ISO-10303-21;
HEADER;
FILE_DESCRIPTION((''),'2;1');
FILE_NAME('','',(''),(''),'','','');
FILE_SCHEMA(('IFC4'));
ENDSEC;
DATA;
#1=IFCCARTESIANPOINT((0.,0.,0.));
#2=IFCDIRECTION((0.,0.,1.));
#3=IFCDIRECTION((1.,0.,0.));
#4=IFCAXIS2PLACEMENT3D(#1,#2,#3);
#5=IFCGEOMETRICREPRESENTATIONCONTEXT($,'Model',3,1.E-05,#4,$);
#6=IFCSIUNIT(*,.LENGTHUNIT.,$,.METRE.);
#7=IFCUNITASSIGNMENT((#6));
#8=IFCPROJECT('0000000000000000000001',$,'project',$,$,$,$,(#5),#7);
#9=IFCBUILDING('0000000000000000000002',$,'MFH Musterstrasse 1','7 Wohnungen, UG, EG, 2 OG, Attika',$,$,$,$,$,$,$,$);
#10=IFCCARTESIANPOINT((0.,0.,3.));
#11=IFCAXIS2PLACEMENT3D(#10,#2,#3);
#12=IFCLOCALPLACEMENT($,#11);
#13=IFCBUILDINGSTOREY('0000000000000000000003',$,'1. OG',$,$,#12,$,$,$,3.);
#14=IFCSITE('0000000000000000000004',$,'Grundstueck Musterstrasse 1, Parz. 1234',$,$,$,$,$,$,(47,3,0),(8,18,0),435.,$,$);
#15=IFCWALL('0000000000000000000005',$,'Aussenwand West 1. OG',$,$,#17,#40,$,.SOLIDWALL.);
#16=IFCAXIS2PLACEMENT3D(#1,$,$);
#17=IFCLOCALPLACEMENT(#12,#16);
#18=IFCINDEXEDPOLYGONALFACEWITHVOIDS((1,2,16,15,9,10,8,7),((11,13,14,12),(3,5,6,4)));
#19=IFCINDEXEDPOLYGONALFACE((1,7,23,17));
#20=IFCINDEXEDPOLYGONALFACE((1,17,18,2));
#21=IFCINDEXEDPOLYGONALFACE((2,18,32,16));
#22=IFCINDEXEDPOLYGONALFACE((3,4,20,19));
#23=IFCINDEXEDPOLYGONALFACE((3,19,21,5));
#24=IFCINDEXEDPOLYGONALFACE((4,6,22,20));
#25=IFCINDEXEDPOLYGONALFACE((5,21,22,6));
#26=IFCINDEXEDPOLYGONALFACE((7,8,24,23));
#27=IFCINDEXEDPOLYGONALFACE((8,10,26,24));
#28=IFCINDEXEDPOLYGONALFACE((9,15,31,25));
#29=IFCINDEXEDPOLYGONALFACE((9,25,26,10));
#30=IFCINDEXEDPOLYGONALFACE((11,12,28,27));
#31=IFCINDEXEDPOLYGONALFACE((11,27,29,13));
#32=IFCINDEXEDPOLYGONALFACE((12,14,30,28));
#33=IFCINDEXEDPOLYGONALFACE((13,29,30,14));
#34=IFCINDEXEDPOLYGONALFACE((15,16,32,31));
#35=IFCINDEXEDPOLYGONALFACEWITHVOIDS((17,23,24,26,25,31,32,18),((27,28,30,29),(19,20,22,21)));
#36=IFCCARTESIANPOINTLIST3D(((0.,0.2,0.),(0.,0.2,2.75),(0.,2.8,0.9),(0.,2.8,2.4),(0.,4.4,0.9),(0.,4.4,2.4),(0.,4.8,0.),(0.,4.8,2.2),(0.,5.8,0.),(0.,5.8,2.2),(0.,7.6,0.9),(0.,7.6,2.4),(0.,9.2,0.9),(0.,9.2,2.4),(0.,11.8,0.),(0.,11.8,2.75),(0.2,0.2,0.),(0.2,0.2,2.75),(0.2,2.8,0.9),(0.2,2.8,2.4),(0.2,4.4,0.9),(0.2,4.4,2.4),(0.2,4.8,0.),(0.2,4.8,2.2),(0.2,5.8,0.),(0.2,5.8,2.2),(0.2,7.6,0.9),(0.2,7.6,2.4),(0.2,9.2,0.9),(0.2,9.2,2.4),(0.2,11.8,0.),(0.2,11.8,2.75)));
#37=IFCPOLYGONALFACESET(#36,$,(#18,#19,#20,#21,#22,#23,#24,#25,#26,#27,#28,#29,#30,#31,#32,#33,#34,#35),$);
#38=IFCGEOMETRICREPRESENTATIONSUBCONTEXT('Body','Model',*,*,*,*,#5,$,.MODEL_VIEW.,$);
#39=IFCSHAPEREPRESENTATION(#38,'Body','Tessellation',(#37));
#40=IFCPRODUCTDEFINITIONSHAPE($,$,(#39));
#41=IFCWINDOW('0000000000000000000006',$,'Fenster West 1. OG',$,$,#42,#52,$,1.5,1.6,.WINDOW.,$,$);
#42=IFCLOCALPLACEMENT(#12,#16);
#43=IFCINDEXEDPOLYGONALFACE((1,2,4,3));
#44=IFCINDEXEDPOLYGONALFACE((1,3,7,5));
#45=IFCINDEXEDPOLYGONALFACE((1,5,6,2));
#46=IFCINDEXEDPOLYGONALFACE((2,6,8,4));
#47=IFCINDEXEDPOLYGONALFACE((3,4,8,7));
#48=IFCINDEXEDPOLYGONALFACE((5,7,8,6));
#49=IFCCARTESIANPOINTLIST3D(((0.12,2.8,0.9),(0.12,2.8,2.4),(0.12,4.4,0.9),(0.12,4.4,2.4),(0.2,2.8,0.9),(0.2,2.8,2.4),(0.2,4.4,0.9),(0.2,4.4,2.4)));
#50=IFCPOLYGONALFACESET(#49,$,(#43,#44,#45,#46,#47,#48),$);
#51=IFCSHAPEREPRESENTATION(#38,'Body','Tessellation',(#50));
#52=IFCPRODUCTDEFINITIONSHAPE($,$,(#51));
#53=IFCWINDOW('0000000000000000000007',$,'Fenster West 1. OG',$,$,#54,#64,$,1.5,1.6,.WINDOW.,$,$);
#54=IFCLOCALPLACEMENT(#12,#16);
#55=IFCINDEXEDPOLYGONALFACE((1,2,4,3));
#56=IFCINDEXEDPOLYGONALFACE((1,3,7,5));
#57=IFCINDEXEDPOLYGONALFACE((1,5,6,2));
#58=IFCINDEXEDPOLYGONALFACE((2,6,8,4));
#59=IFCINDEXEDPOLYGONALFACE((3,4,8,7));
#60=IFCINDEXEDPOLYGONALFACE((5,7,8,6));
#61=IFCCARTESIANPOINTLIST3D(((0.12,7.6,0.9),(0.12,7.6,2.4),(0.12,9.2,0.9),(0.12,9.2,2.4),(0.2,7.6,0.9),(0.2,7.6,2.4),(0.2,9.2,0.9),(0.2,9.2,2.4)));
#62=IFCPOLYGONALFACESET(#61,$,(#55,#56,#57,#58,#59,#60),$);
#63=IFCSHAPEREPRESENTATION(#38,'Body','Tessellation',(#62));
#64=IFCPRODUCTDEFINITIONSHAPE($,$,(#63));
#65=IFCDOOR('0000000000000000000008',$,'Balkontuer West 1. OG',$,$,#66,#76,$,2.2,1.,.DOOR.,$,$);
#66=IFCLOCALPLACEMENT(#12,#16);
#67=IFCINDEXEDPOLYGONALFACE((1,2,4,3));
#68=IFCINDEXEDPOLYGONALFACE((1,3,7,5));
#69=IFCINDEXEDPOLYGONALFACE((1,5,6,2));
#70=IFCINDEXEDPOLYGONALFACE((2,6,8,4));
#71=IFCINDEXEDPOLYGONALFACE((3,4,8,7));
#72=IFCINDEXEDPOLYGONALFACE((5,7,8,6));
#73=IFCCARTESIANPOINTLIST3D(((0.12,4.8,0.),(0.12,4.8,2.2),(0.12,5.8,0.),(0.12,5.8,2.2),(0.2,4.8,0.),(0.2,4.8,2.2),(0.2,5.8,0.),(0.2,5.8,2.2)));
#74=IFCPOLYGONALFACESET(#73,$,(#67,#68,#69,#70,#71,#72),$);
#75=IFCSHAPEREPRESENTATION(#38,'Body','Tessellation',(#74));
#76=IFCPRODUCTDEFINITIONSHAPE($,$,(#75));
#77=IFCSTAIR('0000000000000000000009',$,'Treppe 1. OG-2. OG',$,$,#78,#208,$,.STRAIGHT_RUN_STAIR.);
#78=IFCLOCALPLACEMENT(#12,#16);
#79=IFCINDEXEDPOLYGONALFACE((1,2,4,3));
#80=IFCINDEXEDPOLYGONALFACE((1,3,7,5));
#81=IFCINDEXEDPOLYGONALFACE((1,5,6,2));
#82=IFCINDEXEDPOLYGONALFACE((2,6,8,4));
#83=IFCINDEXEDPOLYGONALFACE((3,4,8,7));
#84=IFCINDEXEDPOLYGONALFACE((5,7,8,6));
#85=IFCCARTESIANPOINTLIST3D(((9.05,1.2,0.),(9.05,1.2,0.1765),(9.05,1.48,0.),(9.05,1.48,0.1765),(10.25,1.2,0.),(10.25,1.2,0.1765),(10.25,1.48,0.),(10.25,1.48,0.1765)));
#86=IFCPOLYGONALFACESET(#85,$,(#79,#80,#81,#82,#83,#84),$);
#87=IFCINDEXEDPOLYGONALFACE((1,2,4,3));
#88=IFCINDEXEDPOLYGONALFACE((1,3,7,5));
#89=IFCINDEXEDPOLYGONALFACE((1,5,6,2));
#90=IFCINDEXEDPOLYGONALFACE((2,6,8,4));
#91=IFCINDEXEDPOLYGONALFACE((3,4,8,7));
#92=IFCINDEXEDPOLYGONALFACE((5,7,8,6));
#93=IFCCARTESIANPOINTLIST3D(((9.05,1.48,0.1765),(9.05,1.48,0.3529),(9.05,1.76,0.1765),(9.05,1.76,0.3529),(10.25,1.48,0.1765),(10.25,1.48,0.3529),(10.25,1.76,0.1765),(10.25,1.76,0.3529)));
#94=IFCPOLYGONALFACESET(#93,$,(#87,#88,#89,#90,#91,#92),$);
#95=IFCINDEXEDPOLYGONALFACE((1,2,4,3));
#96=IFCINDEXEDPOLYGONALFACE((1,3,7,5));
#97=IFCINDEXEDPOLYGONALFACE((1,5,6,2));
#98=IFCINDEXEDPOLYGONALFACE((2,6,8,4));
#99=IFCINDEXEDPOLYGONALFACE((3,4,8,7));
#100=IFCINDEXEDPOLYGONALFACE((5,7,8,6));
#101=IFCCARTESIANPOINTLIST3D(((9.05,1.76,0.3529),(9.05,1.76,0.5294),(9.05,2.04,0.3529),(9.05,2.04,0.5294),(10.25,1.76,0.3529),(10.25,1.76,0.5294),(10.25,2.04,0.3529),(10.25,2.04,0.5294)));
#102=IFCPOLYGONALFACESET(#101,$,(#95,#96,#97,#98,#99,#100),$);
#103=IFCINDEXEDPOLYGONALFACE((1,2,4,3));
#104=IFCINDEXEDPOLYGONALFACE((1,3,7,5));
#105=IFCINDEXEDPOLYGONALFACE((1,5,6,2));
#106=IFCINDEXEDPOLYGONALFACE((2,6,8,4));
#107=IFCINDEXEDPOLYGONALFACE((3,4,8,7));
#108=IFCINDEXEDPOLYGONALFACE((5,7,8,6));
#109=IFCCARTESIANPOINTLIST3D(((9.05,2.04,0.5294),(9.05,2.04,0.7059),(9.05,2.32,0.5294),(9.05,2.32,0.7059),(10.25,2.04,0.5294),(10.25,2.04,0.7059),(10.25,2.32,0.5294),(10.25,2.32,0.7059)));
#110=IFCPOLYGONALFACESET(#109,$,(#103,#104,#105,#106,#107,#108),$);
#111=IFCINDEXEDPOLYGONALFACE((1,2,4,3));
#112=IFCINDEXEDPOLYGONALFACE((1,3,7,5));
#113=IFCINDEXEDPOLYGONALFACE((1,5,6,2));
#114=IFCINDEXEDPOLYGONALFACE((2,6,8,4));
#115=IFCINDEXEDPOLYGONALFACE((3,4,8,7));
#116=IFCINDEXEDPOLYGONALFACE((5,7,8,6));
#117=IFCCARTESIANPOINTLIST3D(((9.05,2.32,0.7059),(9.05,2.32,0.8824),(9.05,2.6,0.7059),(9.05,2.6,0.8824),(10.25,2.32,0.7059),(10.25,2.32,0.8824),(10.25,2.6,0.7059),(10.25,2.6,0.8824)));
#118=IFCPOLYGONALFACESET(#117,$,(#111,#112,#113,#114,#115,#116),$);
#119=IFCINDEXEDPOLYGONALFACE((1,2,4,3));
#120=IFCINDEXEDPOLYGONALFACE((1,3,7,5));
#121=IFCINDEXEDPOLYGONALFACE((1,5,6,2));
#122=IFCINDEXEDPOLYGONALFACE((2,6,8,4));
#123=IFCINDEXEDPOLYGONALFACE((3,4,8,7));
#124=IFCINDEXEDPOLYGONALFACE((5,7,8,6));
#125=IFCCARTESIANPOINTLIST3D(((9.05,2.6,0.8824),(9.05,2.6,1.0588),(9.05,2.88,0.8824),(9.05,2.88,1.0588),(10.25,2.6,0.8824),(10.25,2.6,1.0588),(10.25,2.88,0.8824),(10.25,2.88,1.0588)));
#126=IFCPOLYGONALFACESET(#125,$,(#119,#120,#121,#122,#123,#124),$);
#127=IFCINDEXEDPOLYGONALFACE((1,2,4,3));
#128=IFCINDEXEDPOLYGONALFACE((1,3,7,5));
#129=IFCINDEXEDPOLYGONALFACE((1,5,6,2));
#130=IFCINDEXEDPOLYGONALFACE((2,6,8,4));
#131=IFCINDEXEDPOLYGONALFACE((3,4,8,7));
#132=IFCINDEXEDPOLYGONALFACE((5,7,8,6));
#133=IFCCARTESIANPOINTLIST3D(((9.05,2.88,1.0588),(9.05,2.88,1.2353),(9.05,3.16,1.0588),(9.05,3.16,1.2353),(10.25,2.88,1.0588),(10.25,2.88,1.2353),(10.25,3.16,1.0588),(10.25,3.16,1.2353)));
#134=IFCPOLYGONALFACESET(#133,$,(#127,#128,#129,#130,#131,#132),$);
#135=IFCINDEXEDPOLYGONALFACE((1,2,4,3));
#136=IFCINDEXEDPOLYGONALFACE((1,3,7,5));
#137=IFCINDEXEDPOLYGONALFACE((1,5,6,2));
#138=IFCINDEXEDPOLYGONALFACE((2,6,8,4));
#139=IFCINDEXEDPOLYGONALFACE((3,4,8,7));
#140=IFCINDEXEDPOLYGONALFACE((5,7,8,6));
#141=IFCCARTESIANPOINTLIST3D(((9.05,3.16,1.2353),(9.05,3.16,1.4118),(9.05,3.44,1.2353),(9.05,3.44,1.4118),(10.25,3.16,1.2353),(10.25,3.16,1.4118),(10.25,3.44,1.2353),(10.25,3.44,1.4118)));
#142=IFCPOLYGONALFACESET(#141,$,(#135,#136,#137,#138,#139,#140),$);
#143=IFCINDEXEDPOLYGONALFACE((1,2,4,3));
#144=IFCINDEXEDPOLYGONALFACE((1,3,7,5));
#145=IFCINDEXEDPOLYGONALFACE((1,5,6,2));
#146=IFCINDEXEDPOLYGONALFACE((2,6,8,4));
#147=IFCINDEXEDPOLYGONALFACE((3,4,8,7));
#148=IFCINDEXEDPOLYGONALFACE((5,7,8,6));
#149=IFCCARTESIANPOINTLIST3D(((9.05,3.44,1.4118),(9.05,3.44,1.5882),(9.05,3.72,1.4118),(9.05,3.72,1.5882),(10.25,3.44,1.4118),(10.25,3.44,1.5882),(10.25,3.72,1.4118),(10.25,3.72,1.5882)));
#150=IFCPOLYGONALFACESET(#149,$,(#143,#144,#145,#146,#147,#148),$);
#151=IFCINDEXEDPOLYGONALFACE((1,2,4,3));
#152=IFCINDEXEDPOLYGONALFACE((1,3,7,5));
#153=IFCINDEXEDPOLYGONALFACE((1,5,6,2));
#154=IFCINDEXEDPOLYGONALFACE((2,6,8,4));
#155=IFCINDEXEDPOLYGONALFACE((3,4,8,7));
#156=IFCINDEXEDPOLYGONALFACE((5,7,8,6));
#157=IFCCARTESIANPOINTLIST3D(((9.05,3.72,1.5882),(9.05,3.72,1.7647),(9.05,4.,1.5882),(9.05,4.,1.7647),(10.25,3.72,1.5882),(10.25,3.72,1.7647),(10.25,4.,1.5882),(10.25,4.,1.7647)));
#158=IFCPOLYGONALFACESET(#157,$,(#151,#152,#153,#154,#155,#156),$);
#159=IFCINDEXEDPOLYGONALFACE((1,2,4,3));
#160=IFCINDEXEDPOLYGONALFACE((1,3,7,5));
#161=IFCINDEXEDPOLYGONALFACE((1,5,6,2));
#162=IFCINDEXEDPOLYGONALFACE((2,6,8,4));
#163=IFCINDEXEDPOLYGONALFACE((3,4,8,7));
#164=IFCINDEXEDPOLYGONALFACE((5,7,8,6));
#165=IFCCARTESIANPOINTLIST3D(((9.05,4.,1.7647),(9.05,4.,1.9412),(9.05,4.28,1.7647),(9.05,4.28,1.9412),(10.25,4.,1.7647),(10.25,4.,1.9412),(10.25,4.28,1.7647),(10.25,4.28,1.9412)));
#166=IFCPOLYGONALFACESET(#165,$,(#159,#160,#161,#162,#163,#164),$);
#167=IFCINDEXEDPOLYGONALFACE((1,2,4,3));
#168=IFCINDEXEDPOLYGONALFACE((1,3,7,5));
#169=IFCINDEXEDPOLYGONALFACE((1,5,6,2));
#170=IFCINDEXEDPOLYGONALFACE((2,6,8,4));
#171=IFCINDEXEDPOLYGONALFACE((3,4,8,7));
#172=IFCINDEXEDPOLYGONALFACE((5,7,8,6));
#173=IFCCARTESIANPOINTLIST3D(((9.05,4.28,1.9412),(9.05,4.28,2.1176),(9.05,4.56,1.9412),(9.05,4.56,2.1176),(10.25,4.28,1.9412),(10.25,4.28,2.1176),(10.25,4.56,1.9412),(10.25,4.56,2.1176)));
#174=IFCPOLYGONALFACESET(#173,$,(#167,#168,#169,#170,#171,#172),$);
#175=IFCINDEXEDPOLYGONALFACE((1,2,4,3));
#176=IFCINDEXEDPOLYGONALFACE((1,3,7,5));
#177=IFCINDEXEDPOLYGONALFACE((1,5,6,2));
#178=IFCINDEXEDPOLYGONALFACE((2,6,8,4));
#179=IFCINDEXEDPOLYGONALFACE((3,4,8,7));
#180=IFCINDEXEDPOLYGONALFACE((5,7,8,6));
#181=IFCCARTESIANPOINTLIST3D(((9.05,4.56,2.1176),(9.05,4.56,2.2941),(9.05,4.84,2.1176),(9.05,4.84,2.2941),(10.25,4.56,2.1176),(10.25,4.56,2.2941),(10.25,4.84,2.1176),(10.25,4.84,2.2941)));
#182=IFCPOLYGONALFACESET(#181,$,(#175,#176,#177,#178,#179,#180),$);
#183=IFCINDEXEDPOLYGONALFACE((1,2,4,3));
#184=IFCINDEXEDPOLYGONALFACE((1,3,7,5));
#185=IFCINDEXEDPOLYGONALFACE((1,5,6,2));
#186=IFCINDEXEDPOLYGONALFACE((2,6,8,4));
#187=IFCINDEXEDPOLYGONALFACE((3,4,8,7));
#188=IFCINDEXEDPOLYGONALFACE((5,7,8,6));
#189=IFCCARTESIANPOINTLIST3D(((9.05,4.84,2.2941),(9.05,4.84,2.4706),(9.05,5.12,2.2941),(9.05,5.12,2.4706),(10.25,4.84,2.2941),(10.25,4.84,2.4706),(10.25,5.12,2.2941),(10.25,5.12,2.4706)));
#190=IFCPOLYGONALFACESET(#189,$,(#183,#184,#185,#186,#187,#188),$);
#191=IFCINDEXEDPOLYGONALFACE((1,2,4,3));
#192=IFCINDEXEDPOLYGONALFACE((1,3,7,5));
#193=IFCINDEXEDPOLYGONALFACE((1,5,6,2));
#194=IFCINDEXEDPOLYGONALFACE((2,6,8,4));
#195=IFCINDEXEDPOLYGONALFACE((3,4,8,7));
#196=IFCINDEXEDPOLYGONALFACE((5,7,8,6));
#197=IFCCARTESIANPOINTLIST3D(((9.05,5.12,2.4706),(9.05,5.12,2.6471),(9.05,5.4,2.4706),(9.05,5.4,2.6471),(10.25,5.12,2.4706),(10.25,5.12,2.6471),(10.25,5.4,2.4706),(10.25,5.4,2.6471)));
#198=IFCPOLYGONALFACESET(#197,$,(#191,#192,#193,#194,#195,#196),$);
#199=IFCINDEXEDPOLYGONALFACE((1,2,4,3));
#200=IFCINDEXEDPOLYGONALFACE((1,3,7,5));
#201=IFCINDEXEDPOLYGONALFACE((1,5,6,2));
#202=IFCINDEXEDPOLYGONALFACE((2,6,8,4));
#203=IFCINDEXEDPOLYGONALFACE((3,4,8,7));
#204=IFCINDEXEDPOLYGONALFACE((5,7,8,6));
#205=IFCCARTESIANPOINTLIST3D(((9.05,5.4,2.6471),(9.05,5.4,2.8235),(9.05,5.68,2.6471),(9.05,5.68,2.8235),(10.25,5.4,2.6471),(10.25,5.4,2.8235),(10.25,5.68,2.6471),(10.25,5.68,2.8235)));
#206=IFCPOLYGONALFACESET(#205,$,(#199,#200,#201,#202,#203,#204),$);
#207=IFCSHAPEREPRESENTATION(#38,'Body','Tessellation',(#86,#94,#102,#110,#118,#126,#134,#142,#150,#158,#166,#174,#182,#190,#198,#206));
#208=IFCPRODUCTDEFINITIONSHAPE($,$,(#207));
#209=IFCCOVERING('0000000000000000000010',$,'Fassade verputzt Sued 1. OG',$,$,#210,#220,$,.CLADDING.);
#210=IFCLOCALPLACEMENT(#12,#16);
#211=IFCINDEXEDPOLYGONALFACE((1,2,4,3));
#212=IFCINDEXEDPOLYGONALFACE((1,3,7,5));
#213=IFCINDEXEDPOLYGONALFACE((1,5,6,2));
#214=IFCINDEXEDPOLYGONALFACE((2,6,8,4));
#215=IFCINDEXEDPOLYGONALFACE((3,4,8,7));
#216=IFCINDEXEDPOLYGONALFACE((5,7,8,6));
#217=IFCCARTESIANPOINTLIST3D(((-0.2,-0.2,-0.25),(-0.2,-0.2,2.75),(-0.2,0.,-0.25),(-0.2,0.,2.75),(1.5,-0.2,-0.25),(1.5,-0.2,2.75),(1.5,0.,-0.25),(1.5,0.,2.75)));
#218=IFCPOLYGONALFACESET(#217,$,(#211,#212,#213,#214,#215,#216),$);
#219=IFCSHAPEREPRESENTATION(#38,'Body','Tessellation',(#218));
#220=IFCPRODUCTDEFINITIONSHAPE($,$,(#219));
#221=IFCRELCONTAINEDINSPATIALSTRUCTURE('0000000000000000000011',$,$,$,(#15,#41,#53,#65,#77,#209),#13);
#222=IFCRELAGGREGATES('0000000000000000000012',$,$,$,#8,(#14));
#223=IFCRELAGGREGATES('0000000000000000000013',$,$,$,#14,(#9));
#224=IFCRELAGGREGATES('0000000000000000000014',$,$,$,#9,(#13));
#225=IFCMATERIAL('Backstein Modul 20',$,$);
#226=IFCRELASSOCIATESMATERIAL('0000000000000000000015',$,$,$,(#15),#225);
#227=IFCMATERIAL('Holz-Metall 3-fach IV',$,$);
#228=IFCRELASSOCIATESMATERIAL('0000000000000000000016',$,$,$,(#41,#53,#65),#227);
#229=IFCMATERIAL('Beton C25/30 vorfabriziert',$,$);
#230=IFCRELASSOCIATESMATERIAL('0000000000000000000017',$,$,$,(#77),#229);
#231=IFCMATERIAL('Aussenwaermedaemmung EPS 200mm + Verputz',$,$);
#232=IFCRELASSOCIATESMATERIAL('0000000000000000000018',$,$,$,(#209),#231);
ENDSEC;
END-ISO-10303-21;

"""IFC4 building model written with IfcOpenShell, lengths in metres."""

from ifc_helpers import new_model, si_unit, frame, frame_2d, origin_with_axes, place, context, subcontext, project, spatial, rectangle, extrude, material, element, fill, save


model = new_model("IFC4")

# Units and contexts
model_context = context("Model", 3, precision=1e-05, world=origin_with_axes())
body_context = subcontext(model_context, "Body", "Model", "MODEL_VIEW")
ifc_project = project(units=[si_unit("LENGTHUNIT", "METRE")], contexts=[model_context])

# Site, building, storey
site = spatial("IfcSite", under=ifc_project, Name="Grundstueck Musterstrasse 1, Parz. 1234", RefLatitude=(47, 3, 0), RefLongitude=(8, 18, 0), RefElevation=435.0)
building = spatial("IfcBuilding", under=site, Name="MFH Musterstrasse 1", Description="7 Wohnungen, UG, EG, 2 OG, Attika")
storey_placement = place(None, frame((0.0, 0.0, 3.0), z_axis=(0.0, 0.0, 1.0), x_axis=(1.0, 0.0, 0.0)))
storey = spatial("IfcBuildingStorey", under=building, at=storey_placement, Name="1. OG", Elevation=3.0)

# Shared definitions
ifc_material_1 = material(Name="Backstein Modul 20")

# Shared definitions
ifc_material_2 = material(Name="Holz-Metall 3-fach IV")

# Wall, openings, windows, door
wall_1_placement = place(storey_placement, frame((0.0, 0.2, 0.0), z_axis=(0.0, 0.0, 1.0), x_axis=(1.0, 0.0, 0.0)))
wall_1 = element("IfcWall", 1, at=wall_1_placement, inside=storey, material=ifc_material_1, Name="Aussenwand West 1. OG", PredefinedType="SOLIDWALL", context=body_context, shape_type="SweptSolid", body=[
    extrude(rectangle(XDim=0.2, YDim=11.6, at=frame_2d((0.1, 5.8))), origin_with_axes(), (0.0, 0.0, 1.0), 2.75),
])
opening_1_placement = place(wall_1_placement, frame((-0.21, 2.6, 0.9), z_axis=(0.0, 0.0, 1.0), x_axis=(1.0, 0.0, 0.0)))
opening_1 = element("IfcOpeningElement", 2, at=opening_1_placement, cuts=wall_1, context=body_context, shape_type="SweptSolid", body=[
    extrude(rectangle(XDim=0.42, YDim=1.6, at=frame_2d((0.21, 0.8))), origin_with_axes(), (0.0, 0.0, 1.0), 1.5),
])
opening_2_placement = place(wall_1_placement, frame((-0.21, 7.4, 0.9), z_axis=(0.0, 0.0, 1.0), x_axis=(1.0, 0.0, 0.0)))
opening_2 = element("IfcOpeningElement", 3, at=opening_2_placement, cuts=wall_1, context=body_context, shape_type="SweptSolid", body=[
    extrude(rectangle(XDim=0.42, YDim=1.6, at=frame_2d((0.21, 0.8))), origin_with_axes(), (0.0, 0.0, 1.0), 1.5),
])
opening_3_placement = place(wall_1_placement, frame((-0.21, 4.6, 0.0), z_axis=(0.0, 0.0, 1.0), x_axis=(1.0, 0.0, 0.0)))
opening_3 = element("IfcOpeningElement", 4, at=opening_3_placement, cuts=wall_1, context=body_context, shape_type="SweptSolid", body=[
    extrude(rectangle(XDim=0.42, YDim=1.0, at=frame_2d((0.21, 0.5))), origin_with_axes(), (0.0, 0.0, 1.0), 2.2),
])
window_1_placement = place(storey_placement, frame((0.12, 2.8, 0.9), z_axis=(0.0, 0.0, 1.0), x_axis=(1.0, 0.0, 0.0)))
window_1 = element("IfcWindow", 5, at=window_1_placement, inside=storey, material=ifc_material_2, Name="Fenster West 1. OG", OverallHeight=1.5, OverallWidth=1.6, PredefinedType="WINDOW", context=body_context, shape_type="SweptSolid", body=[
    extrude(rectangle(XDim=0.08, YDim=1.6, at=frame_2d((0.04, 0.8))), origin_with_axes(), (0.0, 0.0, 1.0), 1.5),
])
fill(opening_1, window_1)
window_2_placement = place(storey_placement, frame((0.12, 7.6, 0.9), z_axis=(0.0, 0.0, 1.0), x_axis=(1.0, 0.0, 0.0)))
window_2 = element("IfcWindow", 6, at=window_2_placement, inside=storey, material=ifc_material_2, Name="Fenster West 1. OG", OverallHeight=1.5, OverallWidth=1.6, PredefinedType="WINDOW", context=body_context, shape_type="SweptSolid", body=[
    extrude(rectangle(XDim=0.08, YDim=1.6, at=frame_2d((0.04, 0.8))), origin_with_axes(), (0.0, 0.0, 1.0), 1.5),
])
fill(opening_2, window_2)
door_1_placement = place(storey_placement, frame((0.12, 4.8, 0.0), z_axis=(0.0, 0.0, 1.0), x_axis=(1.0, 0.0, 0.0)))
door_1 = element("IfcDoor", 7, at=door_1_placement, inside=storey, material=ifc_material_2, Name="Balkontuer West 1. OG", OverallHeight=2.2, OverallWidth=1.0, PredefinedType="DOOR", context=body_context, shape_type="SweptSolid", body=[
    extrude(rectangle(XDim=0.08, YDim=1.0, at=frame_2d((0.04, 0.5))), origin_with_axes(), (0.0, 0.0, 1.0), 2.2),
])
fill(opening_3, door_1)

# Stair
ifc_material_3 = material(Name="Beton C25/30 vorfabriziert")
stair_placement = place(storey_placement, origin_with_axes())
element("IfcStair", 8, at=stair_placement, inside=storey, material=ifc_material_3, Name="Treppe 1. OG-2. OG", PredefinedType="STRAIGHT_RUN_STAIR", context=body_context, shape_type="SweptSolid", body=[
    extrude(rectangle(XDim=1.2, YDim=0.28, at=frame_2d((0.6, 0.14))), frame((9.05, 1.2, 0.0)), (0.0, 0.0, 1.0), 0.1765),
    extrude(rectangle(XDim=1.2, YDim=0.28, at=frame_2d((0.6, 0.14))), frame((9.05, 1.48, 0.1765)), (0.0, 0.0, 1.0), 0.1765),
    extrude(rectangle(XDim=1.2, YDim=0.28, at=frame_2d((0.6, 0.14))), frame((9.05, 1.76, 0.3529)), (0.0, 0.0, 1.0), 0.1765),
    extrude(rectangle(XDim=1.2, YDim=0.28, at=frame_2d((0.6, 0.14))), frame((9.05, 2.04, 0.5294)), (0.0, 0.0, 1.0), 0.1765),
    extrude(rectangle(XDim=1.2, YDim=0.28, at=frame_2d((0.6, 0.14))), frame((9.05, 2.32, 0.7059)), (0.0, 0.0, 1.0), 0.1765),
    extrude(rectangle(XDim=1.2, YDim=0.28, at=frame_2d((0.6, 0.14))), frame((9.05, 2.6, 0.8824)), (0.0, 0.0, 1.0), 0.1765),
    extrude(rectangle(XDim=1.2, YDim=0.28, at=frame_2d((0.6, 0.14))), frame((9.05, 2.88, 1.0588)), (0.0, 0.0, 1.0), 0.1765),
    extrude(rectangle(XDim=1.2, YDim=0.28, at=frame_2d((0.6, 0.14))), frame((9.05, 3.16, 1.2353)), (0.0, 0.0, 1.0), 0.1765),
    extrude(rectangle(XDim=1.2, YDim=0.28, at=frame_2d((0.6, 0.14))), frame((9.05, 3.44, 1.4118)), (0.0, 0.0, 1.0), 0.1765),
    extrude(rectangle(XDim=1.2, YDim=0.28, at=frame_2d((0.6, 0.14))), frame((9.05, 3.72, 1.5882)), (0.0, 0.0, 1.0), 0.1765),
    extrude(rectangle(XDim=1.2, YDim=0.28, at=frame_2d((0.6, 0.14))), frame((9.05, 4.0, 1.7647)), (0.0, 0.0, 1.0), 0.1765),
    extrude(rectangle(XDim=1.2, YDim=0.28, at=frame_2d((0.6, 0.14))), frame((9.05, 4.28, 1.9412)), (0.0, 0.0, 1.0), 0.1765),
    extrude(rectangle(XDim=1.2, YDim=0.28, at=frame_2d((0.6, 0.14))), frame((9.05, 4.56, 2.1176)), (0.0, 0.0, 1.0), 0.1765),
    extrude(rectangle(XDim=1.2, YDim=0.28, at=frame_2d((0.6, 0.14))), frame((9.05, 4.84, 2.2941)), (0.0, 0.0, 1.0), 0.1765),
    extrude(rectangle(XDim=1.2, YDim=0.28, at=frame_2d((0.6, 0.14))), frame((9.05, 5.12, 2.4706)), (0.0, 0.0, 1.0), 0.1765),
    extrude(rectangle(XDim=1.2, YDim=0.28, at=frame_2d((0.6, 0.14))), frame((9.05, 5.4, 2.6471)), (0.0, 0.0, 1.0), 0.1765),
])

# Shared definitions
ifc_material_4 = material(Name="Aussenwaermedaemmung EPS 200mm + Verputz")

# Covering
covering_1_placement = place(storey_placement, frame((-0.2, -0.2, -0.25), z_axis=(0.0, 0.0, 1.0), x_axis=(1.0, 0.0, 0.0)))
element("IfcCovering", 9, at=covering_1_placement, inside=storey, material=ifc_material_4, Name="Fassade verputzt Sued 1. OG", PredefinedType="CLADDING", context=body_context, shape_type="SweptSolid", body=[
    extrude(rectangle(XDim=1.7, YDim=0.2, at=frame_2d((0.85, 0.1))), origin_with_axes(), (0.0, 0.0, 1.0), 3.0),
])

save(model, "model.ifc")
